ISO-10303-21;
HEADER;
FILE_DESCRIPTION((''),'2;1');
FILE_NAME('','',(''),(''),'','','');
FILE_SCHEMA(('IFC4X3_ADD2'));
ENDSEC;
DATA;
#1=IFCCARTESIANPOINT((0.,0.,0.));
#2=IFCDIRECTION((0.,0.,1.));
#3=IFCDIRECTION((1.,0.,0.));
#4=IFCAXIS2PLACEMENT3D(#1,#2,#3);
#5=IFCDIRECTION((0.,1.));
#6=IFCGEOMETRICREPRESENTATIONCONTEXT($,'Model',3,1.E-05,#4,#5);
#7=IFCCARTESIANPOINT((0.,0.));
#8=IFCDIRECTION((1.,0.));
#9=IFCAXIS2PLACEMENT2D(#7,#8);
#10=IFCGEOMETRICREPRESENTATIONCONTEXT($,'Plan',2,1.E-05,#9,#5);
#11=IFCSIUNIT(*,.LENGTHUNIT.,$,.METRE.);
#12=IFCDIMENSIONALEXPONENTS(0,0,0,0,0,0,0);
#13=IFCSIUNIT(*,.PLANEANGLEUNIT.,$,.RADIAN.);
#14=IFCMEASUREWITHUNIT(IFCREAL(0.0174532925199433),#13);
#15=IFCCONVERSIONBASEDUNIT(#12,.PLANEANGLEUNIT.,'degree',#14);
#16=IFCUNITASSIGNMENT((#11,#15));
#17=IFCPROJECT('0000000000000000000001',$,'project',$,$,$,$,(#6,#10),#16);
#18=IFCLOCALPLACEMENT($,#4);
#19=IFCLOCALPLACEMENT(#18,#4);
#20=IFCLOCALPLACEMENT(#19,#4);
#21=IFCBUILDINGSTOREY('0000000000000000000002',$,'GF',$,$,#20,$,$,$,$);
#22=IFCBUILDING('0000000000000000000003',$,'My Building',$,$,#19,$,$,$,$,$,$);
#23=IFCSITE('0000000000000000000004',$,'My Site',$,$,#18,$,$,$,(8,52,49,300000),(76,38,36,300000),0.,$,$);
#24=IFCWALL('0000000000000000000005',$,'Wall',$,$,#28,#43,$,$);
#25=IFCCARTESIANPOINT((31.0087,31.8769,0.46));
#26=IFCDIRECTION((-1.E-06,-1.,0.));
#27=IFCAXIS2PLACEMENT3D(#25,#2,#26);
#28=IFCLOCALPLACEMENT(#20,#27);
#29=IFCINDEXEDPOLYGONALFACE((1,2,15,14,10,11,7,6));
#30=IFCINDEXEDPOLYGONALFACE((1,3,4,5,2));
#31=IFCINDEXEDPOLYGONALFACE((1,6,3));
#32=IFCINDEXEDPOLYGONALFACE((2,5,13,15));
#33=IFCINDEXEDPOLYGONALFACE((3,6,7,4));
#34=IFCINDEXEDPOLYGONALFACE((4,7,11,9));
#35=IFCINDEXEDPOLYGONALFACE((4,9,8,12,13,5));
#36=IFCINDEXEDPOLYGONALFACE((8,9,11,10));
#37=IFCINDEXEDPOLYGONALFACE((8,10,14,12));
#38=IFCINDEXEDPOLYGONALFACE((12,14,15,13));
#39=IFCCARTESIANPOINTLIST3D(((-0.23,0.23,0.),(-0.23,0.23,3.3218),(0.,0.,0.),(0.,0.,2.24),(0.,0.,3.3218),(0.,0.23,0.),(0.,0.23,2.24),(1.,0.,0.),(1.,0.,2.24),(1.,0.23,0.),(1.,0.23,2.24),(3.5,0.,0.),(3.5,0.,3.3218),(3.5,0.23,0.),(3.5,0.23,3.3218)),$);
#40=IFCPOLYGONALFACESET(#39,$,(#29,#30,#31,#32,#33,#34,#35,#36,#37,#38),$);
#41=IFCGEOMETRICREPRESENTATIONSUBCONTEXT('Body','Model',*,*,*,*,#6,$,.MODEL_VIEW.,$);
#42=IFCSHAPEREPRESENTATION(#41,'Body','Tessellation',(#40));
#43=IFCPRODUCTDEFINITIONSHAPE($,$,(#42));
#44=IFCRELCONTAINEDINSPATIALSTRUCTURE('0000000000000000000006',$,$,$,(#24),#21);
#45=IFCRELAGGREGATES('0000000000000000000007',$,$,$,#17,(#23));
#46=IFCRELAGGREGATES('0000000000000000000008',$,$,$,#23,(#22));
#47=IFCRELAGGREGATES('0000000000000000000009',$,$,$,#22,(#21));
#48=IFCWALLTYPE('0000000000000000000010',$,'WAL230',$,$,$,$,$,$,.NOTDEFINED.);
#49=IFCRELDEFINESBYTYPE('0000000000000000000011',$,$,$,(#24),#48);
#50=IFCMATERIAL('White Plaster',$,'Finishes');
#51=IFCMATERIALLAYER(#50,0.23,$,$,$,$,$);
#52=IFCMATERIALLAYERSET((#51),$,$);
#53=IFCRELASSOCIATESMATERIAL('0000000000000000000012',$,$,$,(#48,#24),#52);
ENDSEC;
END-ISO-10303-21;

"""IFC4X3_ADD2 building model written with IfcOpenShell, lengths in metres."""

from ifc_helpers import new_model, entity, si_unit, converted_unit, direction, frame, origin_with_axes, origin_2d_with_axis, place, context, subcontext, project, spatial, line, indexed_curve, outline, extrude, source, transform, mapped, material, layer, layer_set, layer_usage, type_object, element, save


model = new_model("IFC4X3_ADD2")

# Units and contexts
model_context = context("Model", 3, precision=1e-05, world=origin_with_axes(), true_north=direction((0.0, 1.0)))
plan_context = context("Plan", 2, precision=1e-05, world=origin_2d_with_axis(), true_north=direction((0.0, 1.0)))
body_context = subcontext(model_context, "Body", "Model", "MODEL_VIEW")
ifc_project = project(units=[si_unit("LENGTHUNIT", "METRE"), converted_unit("PLANEANGLEUNIT", "degree", entity("IfcReal", 0.0174532925199433), si_unit("PLANEANGLEUNIT", "RADIAN"), dimensions=[0, 0, 0, 0, 0, 0, 0])], contexts=[model_context, plan_context])

# Site, building, storey
site_placement = place(None, origin_with_axes())
site = spatial("IfcSite", under=ifc_project, at=site_placement, Name="My Site", RefLatitude=(8, 52, 49, 300000), RefLongitude=(76, 38, 36, 300000), RefElevation=0.0)
building_placement = place(site_placement, origin_with_axes())
building = spatial("IfcBuilding", under=site, at=building_placement, Name="My Building")
storey_placement = place(building_placement, origin_with_axes())
storey = spatial("IfcBuildingStorey", under=building, at=storey_placement, Name="GF")

# Wall, opening
ifc_material_1 = material(Name="White Plaster", Category="Finishes")
ifc_layer_1 = layer(ifc_material_1, 0.23)
ifc_layer_set_1 = layer_set([ifc_layer_1])
ifc_layer_usage_1 = layer_usage(ifc_layer_set_1, "AXIS2", "POSITIVE", 0.0)
wall_type_1 = type_object("IfcWallType", Name="WAL230", PredefinedType="NOTDEFINED", material=ifc_layer_set_1)
wall_1_placement = place(storey_placement, frame((31.0087, 31.8769, 0.46), z_axis=(0.0, 0.0, 1.0), x_axis=(-0.000001, -1.0, 0.0)))
wall_1 = element("IfcWall", 1, at=wall_1_placement, inside=storey, type_object=wall_type_1, material=ifc_layer_usage_1, Name="Wall", context=body_context, shape_type="SweptSolid", body=[
    extrude(outline(indexed_curve([(0.0, 0.0), (-0.23, 0.23), (3.5, 0.23), (3.5, 0.0)], segments=[line(1, 2, 3, 4, 1)])), origin_with_axes(), (0.0, 0.0, 1.0), 3.3218),
])
shared_shape = source(origin_with_axes(), body_context, "Body", "SweptSolid", [
    extrude(outline(indexed_curve([(0.0, 0.0), (1.0, 0.0), (1.0, 2.25), (0.0, 2.25)], segments=[line(1, 2, 3, 4, 1)])), frame((0.0, -0.6, 0.0), z_axis=(0.0, -1.0, 0.0), x_axis=(1.0, 0.0, 0.0)), (0.0, 0.0, -1.0), 1.2),
])
opening_placement = place(wall_1_placement, frame((1.0, 0.23, -0.01), z_axis=(0.0, 0.0, 1.0), x_axis=(-1.0, 0.0, 0.0)))
element("IfcOpeningElement", 2, at=opening_placement, cuts=wall_1, PredefinedType="OPENING", context=body_context, shape_type="MappedRepresentation", body=[
    mapped(shared_shape, transform((0.0, 0.0, 0.0), x_axis=(1.0, 0.0, 0.0), y_axis=(0.0, 1.0, 0.0), z_axis=(0.0, 0.0, 1.0), scale=1.0)),
])

save(model, "model.ifc")
